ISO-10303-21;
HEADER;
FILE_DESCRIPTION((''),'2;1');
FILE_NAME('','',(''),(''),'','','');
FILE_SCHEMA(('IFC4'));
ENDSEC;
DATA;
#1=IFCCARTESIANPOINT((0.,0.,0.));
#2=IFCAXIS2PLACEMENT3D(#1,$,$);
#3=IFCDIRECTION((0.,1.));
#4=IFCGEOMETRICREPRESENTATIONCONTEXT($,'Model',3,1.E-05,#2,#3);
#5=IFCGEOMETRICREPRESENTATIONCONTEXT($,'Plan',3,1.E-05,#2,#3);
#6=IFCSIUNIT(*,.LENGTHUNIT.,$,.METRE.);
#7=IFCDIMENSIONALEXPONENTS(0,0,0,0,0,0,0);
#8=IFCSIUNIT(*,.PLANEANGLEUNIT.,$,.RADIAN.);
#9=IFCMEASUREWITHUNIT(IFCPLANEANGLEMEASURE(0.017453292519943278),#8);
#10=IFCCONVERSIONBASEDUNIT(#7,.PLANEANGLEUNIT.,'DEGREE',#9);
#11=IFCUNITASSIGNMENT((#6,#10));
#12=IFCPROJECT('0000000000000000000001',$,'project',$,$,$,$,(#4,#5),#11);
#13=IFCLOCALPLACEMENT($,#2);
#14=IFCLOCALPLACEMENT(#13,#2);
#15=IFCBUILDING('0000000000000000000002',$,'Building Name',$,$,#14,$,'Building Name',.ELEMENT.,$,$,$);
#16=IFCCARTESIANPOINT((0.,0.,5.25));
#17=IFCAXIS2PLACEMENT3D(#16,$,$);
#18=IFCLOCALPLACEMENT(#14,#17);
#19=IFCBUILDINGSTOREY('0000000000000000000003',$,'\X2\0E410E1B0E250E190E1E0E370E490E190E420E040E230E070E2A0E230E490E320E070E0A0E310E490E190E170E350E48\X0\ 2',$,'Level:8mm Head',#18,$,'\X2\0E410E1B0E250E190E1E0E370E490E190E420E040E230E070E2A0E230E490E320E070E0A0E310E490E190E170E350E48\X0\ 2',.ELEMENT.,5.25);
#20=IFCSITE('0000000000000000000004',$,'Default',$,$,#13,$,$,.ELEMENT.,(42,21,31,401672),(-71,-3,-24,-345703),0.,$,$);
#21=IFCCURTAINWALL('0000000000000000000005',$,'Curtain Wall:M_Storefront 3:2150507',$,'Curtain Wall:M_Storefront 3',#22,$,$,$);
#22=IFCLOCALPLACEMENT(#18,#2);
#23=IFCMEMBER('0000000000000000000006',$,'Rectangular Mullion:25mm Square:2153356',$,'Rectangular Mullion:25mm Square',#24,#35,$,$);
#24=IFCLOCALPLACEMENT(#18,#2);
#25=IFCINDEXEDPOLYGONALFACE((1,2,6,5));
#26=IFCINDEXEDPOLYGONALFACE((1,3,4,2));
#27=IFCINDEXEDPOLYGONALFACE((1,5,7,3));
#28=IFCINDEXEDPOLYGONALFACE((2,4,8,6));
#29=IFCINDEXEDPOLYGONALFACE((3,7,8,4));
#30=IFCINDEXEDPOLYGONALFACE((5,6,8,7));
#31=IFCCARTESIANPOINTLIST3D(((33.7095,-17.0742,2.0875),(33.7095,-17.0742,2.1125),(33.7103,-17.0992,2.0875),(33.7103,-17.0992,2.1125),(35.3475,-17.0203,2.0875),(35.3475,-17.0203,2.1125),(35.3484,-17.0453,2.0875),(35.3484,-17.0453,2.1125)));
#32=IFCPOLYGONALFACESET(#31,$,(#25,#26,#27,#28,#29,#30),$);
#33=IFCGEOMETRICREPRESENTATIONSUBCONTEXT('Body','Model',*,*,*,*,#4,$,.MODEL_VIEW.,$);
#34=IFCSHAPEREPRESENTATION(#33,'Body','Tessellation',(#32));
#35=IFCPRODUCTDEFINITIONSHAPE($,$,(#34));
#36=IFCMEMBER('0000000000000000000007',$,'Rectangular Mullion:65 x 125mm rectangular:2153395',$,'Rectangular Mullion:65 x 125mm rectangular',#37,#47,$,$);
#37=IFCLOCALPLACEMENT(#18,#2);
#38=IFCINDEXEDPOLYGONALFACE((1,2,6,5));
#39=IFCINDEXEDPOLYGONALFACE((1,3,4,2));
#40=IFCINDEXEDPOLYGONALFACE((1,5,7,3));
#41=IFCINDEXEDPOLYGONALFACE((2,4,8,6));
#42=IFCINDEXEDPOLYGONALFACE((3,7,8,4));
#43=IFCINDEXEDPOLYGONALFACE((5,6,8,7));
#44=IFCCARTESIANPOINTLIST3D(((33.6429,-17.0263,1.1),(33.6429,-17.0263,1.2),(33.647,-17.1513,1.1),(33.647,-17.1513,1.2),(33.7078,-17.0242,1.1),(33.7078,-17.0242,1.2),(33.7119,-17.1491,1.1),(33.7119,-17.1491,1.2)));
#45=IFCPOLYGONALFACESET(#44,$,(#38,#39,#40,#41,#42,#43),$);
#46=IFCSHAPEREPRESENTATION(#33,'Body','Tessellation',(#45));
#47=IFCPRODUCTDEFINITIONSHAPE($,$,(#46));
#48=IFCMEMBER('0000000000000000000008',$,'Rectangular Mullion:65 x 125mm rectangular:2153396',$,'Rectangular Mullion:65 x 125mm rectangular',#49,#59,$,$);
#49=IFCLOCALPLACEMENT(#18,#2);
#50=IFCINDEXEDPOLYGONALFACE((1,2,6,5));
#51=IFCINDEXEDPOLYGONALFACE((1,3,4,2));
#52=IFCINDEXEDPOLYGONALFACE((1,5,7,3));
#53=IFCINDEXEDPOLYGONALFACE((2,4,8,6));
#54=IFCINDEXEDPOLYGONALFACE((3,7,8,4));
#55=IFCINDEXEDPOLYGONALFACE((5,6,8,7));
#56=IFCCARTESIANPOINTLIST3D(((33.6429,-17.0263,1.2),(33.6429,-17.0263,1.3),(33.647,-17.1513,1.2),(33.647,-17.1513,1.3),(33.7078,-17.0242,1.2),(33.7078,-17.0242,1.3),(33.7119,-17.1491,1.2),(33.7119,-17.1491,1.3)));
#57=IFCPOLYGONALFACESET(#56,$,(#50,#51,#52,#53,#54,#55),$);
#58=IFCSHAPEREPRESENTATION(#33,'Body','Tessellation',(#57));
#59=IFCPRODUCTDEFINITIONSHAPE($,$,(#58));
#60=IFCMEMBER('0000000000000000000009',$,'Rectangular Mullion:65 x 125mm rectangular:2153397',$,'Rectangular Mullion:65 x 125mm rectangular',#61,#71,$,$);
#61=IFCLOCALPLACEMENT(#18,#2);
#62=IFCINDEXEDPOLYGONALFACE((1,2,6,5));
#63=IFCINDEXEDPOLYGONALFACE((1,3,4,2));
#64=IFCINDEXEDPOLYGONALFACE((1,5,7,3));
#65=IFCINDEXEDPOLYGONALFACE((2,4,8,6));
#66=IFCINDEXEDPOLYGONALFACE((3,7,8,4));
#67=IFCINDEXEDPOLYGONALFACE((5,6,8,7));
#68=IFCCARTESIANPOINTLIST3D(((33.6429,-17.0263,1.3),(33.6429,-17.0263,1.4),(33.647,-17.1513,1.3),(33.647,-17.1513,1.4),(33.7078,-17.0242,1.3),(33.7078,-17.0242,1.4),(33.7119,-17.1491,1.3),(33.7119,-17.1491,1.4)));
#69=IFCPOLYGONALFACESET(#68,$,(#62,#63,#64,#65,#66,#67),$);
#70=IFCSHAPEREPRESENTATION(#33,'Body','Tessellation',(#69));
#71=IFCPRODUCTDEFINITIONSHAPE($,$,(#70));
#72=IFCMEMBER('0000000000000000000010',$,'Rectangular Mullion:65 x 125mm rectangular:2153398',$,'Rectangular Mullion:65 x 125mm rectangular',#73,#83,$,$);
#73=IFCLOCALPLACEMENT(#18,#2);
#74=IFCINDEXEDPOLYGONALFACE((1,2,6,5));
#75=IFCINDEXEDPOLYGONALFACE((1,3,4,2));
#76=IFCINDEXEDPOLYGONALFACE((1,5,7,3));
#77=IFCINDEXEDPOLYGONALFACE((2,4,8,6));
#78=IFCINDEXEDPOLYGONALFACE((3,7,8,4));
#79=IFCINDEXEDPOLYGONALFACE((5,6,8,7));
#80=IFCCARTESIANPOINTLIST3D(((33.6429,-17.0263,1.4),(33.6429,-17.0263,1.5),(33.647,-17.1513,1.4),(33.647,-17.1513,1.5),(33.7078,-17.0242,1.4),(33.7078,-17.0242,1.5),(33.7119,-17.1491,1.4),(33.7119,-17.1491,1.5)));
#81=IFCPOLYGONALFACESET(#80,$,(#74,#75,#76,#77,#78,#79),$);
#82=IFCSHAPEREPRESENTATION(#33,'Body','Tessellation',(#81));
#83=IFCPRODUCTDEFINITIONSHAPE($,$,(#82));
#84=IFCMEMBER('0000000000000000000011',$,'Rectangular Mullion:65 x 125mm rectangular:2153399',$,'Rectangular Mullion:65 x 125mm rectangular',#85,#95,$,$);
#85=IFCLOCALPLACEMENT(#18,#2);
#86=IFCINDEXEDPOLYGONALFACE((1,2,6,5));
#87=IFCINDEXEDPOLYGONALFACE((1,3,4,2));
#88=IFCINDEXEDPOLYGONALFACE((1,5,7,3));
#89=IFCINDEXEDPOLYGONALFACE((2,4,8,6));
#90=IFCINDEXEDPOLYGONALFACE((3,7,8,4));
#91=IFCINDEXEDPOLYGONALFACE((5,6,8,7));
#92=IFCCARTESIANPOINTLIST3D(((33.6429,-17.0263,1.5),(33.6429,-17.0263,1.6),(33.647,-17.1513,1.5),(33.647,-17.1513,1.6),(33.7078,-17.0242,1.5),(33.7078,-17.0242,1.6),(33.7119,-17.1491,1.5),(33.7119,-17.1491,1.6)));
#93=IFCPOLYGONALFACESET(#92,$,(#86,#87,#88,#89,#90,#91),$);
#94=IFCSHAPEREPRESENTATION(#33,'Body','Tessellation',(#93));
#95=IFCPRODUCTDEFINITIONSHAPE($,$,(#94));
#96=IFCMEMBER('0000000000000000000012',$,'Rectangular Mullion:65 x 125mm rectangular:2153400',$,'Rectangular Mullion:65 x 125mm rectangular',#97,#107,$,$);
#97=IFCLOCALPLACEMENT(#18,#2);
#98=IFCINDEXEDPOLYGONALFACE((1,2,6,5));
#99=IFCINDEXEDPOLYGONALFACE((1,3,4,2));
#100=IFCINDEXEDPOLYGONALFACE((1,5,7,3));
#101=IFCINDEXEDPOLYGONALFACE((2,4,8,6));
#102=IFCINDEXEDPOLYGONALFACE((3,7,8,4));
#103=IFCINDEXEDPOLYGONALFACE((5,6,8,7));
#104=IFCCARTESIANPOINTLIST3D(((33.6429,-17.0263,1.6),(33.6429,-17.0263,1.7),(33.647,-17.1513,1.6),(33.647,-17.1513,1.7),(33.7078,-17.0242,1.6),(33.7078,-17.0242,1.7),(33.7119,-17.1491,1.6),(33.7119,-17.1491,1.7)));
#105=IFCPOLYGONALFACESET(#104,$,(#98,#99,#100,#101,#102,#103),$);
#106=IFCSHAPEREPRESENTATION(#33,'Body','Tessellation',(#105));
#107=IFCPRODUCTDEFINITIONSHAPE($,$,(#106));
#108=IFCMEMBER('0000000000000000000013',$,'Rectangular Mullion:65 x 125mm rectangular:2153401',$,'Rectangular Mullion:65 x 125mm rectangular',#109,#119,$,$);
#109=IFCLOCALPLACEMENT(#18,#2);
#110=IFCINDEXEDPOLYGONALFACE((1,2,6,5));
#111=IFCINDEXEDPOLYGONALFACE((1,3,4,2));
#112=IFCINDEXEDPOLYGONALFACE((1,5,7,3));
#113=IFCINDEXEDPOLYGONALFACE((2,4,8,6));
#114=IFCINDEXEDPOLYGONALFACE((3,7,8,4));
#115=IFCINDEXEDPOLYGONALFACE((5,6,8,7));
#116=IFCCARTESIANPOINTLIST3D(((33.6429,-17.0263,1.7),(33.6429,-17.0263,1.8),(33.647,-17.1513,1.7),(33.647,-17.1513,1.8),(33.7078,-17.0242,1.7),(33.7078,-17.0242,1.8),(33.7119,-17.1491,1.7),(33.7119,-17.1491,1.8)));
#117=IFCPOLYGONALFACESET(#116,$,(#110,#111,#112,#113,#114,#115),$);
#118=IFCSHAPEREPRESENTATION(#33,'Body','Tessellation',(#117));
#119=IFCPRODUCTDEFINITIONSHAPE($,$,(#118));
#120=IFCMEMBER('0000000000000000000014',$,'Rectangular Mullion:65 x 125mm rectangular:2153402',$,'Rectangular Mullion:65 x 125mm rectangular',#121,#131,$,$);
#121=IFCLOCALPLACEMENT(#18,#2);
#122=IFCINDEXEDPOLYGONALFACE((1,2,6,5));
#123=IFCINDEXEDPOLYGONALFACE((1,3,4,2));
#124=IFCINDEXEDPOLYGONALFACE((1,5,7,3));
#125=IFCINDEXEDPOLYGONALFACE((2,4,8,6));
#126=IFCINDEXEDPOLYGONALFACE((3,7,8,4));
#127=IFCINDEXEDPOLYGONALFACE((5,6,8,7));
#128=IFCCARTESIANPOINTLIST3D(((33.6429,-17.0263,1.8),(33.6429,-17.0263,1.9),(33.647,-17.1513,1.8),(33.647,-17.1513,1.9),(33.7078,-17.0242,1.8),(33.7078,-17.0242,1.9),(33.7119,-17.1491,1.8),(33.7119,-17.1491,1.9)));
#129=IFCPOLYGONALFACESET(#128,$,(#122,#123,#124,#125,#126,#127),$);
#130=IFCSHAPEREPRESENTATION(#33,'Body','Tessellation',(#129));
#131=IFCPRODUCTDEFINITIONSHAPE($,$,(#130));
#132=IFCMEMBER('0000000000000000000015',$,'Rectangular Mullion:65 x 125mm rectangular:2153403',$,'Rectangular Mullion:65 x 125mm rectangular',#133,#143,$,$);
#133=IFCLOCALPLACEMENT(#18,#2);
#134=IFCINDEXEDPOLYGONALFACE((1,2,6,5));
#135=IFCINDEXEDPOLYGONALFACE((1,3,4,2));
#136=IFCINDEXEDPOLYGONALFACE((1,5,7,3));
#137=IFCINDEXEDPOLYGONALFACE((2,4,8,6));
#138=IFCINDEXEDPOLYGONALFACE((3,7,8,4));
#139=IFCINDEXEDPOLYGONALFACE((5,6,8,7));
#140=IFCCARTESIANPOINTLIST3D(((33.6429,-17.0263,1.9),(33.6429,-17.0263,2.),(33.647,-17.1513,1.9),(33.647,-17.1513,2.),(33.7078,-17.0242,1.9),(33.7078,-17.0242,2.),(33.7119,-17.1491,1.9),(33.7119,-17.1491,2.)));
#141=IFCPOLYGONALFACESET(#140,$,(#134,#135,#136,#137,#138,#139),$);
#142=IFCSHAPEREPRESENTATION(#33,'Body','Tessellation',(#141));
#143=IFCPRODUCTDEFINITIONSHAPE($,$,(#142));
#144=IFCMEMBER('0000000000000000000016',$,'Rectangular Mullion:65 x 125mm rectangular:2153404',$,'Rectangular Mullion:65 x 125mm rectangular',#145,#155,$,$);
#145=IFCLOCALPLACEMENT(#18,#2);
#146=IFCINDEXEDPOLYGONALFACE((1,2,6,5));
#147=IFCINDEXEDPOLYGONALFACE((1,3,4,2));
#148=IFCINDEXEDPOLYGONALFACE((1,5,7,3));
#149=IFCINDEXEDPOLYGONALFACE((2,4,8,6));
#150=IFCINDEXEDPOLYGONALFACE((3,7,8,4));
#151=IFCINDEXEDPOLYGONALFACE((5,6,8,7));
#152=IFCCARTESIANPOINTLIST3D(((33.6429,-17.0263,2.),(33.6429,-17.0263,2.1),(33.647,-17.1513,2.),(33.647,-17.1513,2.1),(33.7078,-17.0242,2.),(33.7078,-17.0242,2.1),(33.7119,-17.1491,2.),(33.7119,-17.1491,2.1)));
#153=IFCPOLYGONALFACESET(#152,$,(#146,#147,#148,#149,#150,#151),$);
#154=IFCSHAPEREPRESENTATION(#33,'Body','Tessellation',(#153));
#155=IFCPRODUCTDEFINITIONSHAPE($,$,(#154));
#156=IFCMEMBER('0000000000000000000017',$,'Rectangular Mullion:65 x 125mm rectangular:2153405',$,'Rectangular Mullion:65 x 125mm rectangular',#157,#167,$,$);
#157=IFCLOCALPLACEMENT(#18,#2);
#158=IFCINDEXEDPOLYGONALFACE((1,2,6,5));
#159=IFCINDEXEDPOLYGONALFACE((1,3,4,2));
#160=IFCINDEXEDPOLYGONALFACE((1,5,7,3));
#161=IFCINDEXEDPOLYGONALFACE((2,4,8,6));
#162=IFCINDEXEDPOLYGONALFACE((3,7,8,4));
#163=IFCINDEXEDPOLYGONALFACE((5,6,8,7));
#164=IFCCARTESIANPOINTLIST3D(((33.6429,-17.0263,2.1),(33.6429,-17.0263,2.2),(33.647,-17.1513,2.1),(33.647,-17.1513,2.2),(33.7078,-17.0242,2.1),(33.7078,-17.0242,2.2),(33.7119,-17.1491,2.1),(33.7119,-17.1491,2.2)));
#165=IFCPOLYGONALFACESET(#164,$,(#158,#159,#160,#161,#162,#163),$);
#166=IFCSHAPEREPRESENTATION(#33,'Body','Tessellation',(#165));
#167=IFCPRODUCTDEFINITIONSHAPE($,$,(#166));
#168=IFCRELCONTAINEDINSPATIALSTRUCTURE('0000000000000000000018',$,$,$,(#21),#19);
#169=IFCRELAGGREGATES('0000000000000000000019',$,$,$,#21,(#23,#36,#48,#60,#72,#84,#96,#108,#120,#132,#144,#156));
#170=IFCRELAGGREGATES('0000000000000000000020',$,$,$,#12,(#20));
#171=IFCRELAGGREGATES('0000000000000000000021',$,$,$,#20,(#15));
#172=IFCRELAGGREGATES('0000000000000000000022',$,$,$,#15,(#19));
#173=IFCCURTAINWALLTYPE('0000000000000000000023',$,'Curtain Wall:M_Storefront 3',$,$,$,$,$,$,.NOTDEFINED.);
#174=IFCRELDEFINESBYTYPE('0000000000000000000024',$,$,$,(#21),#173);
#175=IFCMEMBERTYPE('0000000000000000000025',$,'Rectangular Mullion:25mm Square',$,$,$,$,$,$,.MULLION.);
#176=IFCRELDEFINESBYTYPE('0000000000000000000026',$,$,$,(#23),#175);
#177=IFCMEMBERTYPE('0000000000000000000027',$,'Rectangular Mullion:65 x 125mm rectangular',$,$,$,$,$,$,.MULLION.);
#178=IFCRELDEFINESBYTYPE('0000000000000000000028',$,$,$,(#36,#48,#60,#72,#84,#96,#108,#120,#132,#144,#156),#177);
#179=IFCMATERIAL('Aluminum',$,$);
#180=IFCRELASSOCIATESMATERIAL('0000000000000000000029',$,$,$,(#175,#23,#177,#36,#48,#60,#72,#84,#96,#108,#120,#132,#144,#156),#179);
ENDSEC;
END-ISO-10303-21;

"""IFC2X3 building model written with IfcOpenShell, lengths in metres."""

from ifc_helpers import new_model, entity, si_unit, converted_unit, direction, frame, frame_2d, origin, origin_2d_with_axis, place, context, subcontext, project, spatial, rectangle, extrude, source, transform, mapped, material, type_object, type_shapes, element, aggregate, save


model = new_model("IFC2X3")

# Units and contexts
model_context = context("Model", 3, precision=1e-05, world=origin(), true_north=direction((0.0, 1.0)))
plan_context = context("Plan", 3, precision=1e-05, world=origin(), true_north=direction((0.0, 1.0)))
body_context = subcontext(model_context, "Body", "Model", "MODEL_VIEW")
ifc_project = project(units=[si_unit("LENGTHUNIT", "METRE"), converted_unit("PLANEANGLEUNIT", "DEGREE", entity("IfcPlaneAngleMeasure", 0.017453292519943278), si_unit("PLANEANGLEUNIT", "RADIAN"), dimensions=[0, 0, 0, 0, 0, 0, 0])], contexts=[model_context, plan_context])

# Site, building, storey
site_placement = place(None, origin())
site = spatial("IfcSite", under=ifc_project, at=site_placement, Name="Default", CompositionType="ELEMENT", RefLatitude=(42, 21, 31, 401672), RefLongitude=(-71, -3, -24, -345703), RefElevation=0.0)
building_placement = place(site_placement, origin())
building = spatial("IfcBuilding", under=site, at=building_placement, Name="Building Name", LongName="Building Name", CompositionType="ELEMENT")
storey_placement = place(building_placement, frame((0.0, 0.0, 5.25)))
storey = spatial("IfcBuildingStorey", under=building, at=storey_placement, Name="แปลนพื้นโครงสร้างชั้นที่ 2", ObjectType="Level:8mm Head", LongName="แปลนพื้นโครงสร้างชั้นที่ 2", CompositionType="ELEMENT", Elevation=5.25)

# Curtain wall, members
curtain_wall_type = type_object("IfcCurtainWallType", Name="Curtain Wall:M_Storefront 3", PredefinedType="NOTDEFINED")
curtain_wall_placement = place(storey_placement, frame((0.0, 0.0, -5.25)))
curtain_wall = element("IfcCurtainWall", 1, at=curtain_wall_placement, inside=storey, type_object=curtain_wall_type, Name="Curtain Wall:M_Storefront 3:2150507", ObjectType="Curtain Wall:M_Storefront 3")
ifc_material = material(Name="Aluminum")
member_type_1 = type_object("IfcMemberType", Name="Rectangular Mullion:25mm Square", PredefinedType="MULLION", material=ifc_material)
shared_shape_1 = source(origin(), body_context, "Body", "SweptSolid", [
    extrude(rectangle(XDim=0.025, YDim=0.025, at=origin_2d_with_axis()), frame((0.0, 0.0, -1.6389), z_axis=(0.0, 0.0, 1.0), x_axis=(-1.0, 0.0, 0.0)), (0.0, 0.0, 1.0), 1.6389),
])
type_shapes(member_type_1, [shared_shape_1])
member_1_placement = place(curtain_wall_placement, frame((35.348, -17.0328, 7.35), z_axis=(0.99946, 0.032862, 0.0), x_axis=(0.0, 0.0, 1.0)))
member_1 = element("IfcMember", 2, at=member_1_placement, type_object=member_type_1, material=ifc_material, Name="Rectangular Mullion:25mm Square:2153356", ObjectType="Rectangular Mullion:25mm Square", context=body_context, shape_type="MappedRepresentation", body=[
    mapped(shared_shape_1, transform((0.0, 0.0, 0.0), scale=1.0)),
])
member_type_2 = type_object("IfcMemberType", Name="Rectangular Mullion:65 x 125mm rectangular", PredefinedType="MULLION", material=ifc_material)
shared_shape_2 = source(origin(), body_context, "Body", "SweptSolid", [
    extrude(rectangle(XDim=0.065, YDim=0.125, at=frame_2d((0.0, 0.0), x_axis=(1.0, 0.0))), frame((0.0, 0.0, -0.1), z_axis=(0.0, 0.0, 1.0), x_axis=(-1.0, 0.0, 0.0)), (0.0, 0.0, 1.0), 0.1),
])
type_shapes(member_type_2, [shared_shape_2])
member_2_placement = place(curtain_wall_placement, frame((33.6774, -17.0877, 6.35), z_axis=(0.0, 0.0, -1.0), x_axis=(0.99946, 0.032862, 0.0)))
member_2 = element("IfcMember", 3, at=member_2_placement, type_object=member_type_2, material=ifc_material, Name="Rectangular Mullion:65 x 125mm rectangular:2153395", ObjectType="Rectangular Mullion:65 x 125mm rectangular", context=body_context, shape_type="MappedRepresentation", body=[
    mapped(shared_shape_2, transform((0.0, 0.0, 0.0), scale=1.0)),
])
member_3_placement = place(curtain_wall_placement, frame((33.6774, -17.0877, 6.45), z_axis=(0.0, 0.0, -1.0), x_axis=(0.99946, 0.032862, 0.0)))
member_3 = element("IfcMember", 4, at=member_3_placement, type_object=member_type_2, material=ifc_material, Name="Rectangular Mullion:65 x 125mm rectangular:2153396", ObjectType="Rectangular Mullion:65 x 125mm rectangular", context=body_context, shape_type="MappedRepresentation", body=[
    mapped(shared_shape_2, transform((0.0, 0.0, 0.0), scale=1.0)),
])
member_4_placement = place(curtain_wall_placement, frame((33.6774, -17.0877, 6.55), z_axis=(0.0, 0.0, -1.0), x_axis=(0.99946, 0.032862, 0.0)))
member_4 = element("IfcMember", 5, at=member_4_placement, type_object=member_type_2, material=ifc_material, Name="Rectangular Mullion:65 x 125mm rectangular:2153397", ObjectType="Rectangular Mullion:65 x 125mm rectangular", context=body_context, shape_type="MappedRepresentation", body=[
    mapped(shared_shape_2, transform((0.0, 0.0, 0.0), scale=1.0)),
])
member_5_placement = place(curtain_wall_placement, frame((33.6774, -17.0877, 6.65), z_axis=(0.0, 0.0, -1.0), x_axis=(0.99946, 0.032862, 0.0)))
member_5 = element("IfcMember", 6, at=member_5_placement, type_object=member_type_2, material=ifc_material, Name="Rectangular Mullion:65 x 125mm rectangular:2153398", ObjectType="Rectangular Mullion:65 x 125mm rectangular", context=body_context, shape_type="MappedRepresentation", body=[
    mapped(shared_shape_2, transform((0.0, 0.0, 0.0), scale=1.0)),
])
member_6_placement = place(curtain_wall_placement, frame((33.6774, -17.0877, 6.75), z_axis=(0.0, 0.0, -1.0), x_axis=(0.99946, 0.032862, 0.0)))
member_6 = element("IfcMember", 7, at=member_6_placement, type_object=member_type_2, material=ifc_material, Name="Rectangular Mullion:65 x 125mm rectangular:2153399", ObjectType="Rectangular Mullion:65 x 125mm rectangular", context=body_context, shape_type="MappedRepresentation", body=[
    mapped(shared_shape_2, transform((0.0, 0.0, 0.0), scale=1.0)),
])
member_7_placement = place(curtain_wall_placement, frame((33.6774, -17.0877, 6.85), z_axis=(0.0, 0.0, -1.0), x_axis=(0.99946, 0.032862, 0.0)))
member_7 = element("IfcMember", 8, at=member_7_placement, type_object=member_type_2, material=ifc_material, Name="Rectangular Mullion:65 x 125mm rectangular:2153400", ObjectType="Rectangular Mullion:65 x 125mm rectangular", context=body_context, shape_type="MappedRepresentation", body=[
    mapped(shared_shape_2, transform((0.0, 0.0, 0.0), scale=1.0)),
])
member_8_placement = place(curtain_wall_placement, frame((33.6774, -17.0877, 6.95), z_axis=(0.0, 0.0, -1.0), x_axis=(0.99946, 0.032862, 0.0)))
member_8 = element("IfcMember", 9, at=member_8_placement, type_object=member_type_2, material=ifc_material, Name="Rectangular Mullion:65 x 125mm rectangular:2153401", ObjectType="Rectangular Mullion:65 x 125mm rectangular", context=body_context, shape_type="MappedRepresentation", body=[
    mapped(shared_shape_2, transform((0.0, 0.0, 0.0), scale=1.0)),
])
member_9_placement = place(curtain_wall_placement, frame((33.6774, -17.0877, 7.05), z_axis=(0.0, 0.0, -1.0), x_axis=(0.99946, 0.032862, 0.0)))
member_9 = element("IfcMember", 10, at=member_9_placement, type_object=member_type_2, material=ifc_material, Name="Rectangular Mullion:65 x 125mm rectangular:2153402", ObjectType="Rectangular Mullion:65 x 125mm rectangular", context=body_context, shape_type="MappedRepresentation", body=[
    mapped(shared_shape_2, transform((0.0, 0.0, 0.0), scale=1.0)),
])
member_10_placement = place(curtain_wall_placement, frame((33.6774, -17.0877, 7.15), z_axis=(0.0, 0.0, -1.0), x_axis=(0.99946, 0.032862, 0.0)))
member_10 = element("IfcMember", 11, at=member_10_placement, type_object=member_type_2, material=ifc_material, Name="Rectangular Mullion:65 x 125mm rectangular:2153403", ObjectType="Rectangular Mullion:65 x 125mm rectangular", context=body_context, shape_type="MappedRepresentation", body=[
    mapped(shared_shape_2, transform((0.0, 0.0, 0.0), scale=1.0)),
])
member_11_placement = place(curtain_wall_placement, frame((33.6774, -17.0877, 7.25), z_axis=(0.0, 0.0, -1.0), x_axis=(0.99946, 0.032862, 0.0)))
member_11 = element("IfcMember", 12, at=member_11_placement, type_object=member_type_2, material=ifc_material, Name="Rectangular Mullion:65 x 125mm rectangular:2153404", ObjectType="Rectangular Mullion:65 x 125mm rectangular", context=body_context, shape_type="MappedRepresentation", body=[
    mapped(shared_shape_2, transform((0.0, 0.0, 0.0), scale=1.0)),
])
member_12_placement = place(curtain_wall_placement, frame((33.6774, -17.0877, 7.35), z_axis=(0.0, 0.0, -1.0), x_axis=(0.99946, 0.032862, 0.0)))
member_12 = element("IfcMember", 13, at=member_12_placement, type_object=member_type_2, material=ifc_material, Name="Rectangular Mullion:65 x 125mm rectangular:2153405", ObjectType="Rectangular Mullion:65 x 125mm rectangular", context=body_context, shape_type="MappedRepresentation", body=[
    mapped(shared_shape_2, transform((0.0, 0.0, 0.0), scale=1.0)),
])
aggregate(curtain_wall, [member_1, member_2, member_3, member_4, member_5, member_6, member_7, member_8, member_9, member_10, member_11, member_12])

save(model, "model.ifc")
